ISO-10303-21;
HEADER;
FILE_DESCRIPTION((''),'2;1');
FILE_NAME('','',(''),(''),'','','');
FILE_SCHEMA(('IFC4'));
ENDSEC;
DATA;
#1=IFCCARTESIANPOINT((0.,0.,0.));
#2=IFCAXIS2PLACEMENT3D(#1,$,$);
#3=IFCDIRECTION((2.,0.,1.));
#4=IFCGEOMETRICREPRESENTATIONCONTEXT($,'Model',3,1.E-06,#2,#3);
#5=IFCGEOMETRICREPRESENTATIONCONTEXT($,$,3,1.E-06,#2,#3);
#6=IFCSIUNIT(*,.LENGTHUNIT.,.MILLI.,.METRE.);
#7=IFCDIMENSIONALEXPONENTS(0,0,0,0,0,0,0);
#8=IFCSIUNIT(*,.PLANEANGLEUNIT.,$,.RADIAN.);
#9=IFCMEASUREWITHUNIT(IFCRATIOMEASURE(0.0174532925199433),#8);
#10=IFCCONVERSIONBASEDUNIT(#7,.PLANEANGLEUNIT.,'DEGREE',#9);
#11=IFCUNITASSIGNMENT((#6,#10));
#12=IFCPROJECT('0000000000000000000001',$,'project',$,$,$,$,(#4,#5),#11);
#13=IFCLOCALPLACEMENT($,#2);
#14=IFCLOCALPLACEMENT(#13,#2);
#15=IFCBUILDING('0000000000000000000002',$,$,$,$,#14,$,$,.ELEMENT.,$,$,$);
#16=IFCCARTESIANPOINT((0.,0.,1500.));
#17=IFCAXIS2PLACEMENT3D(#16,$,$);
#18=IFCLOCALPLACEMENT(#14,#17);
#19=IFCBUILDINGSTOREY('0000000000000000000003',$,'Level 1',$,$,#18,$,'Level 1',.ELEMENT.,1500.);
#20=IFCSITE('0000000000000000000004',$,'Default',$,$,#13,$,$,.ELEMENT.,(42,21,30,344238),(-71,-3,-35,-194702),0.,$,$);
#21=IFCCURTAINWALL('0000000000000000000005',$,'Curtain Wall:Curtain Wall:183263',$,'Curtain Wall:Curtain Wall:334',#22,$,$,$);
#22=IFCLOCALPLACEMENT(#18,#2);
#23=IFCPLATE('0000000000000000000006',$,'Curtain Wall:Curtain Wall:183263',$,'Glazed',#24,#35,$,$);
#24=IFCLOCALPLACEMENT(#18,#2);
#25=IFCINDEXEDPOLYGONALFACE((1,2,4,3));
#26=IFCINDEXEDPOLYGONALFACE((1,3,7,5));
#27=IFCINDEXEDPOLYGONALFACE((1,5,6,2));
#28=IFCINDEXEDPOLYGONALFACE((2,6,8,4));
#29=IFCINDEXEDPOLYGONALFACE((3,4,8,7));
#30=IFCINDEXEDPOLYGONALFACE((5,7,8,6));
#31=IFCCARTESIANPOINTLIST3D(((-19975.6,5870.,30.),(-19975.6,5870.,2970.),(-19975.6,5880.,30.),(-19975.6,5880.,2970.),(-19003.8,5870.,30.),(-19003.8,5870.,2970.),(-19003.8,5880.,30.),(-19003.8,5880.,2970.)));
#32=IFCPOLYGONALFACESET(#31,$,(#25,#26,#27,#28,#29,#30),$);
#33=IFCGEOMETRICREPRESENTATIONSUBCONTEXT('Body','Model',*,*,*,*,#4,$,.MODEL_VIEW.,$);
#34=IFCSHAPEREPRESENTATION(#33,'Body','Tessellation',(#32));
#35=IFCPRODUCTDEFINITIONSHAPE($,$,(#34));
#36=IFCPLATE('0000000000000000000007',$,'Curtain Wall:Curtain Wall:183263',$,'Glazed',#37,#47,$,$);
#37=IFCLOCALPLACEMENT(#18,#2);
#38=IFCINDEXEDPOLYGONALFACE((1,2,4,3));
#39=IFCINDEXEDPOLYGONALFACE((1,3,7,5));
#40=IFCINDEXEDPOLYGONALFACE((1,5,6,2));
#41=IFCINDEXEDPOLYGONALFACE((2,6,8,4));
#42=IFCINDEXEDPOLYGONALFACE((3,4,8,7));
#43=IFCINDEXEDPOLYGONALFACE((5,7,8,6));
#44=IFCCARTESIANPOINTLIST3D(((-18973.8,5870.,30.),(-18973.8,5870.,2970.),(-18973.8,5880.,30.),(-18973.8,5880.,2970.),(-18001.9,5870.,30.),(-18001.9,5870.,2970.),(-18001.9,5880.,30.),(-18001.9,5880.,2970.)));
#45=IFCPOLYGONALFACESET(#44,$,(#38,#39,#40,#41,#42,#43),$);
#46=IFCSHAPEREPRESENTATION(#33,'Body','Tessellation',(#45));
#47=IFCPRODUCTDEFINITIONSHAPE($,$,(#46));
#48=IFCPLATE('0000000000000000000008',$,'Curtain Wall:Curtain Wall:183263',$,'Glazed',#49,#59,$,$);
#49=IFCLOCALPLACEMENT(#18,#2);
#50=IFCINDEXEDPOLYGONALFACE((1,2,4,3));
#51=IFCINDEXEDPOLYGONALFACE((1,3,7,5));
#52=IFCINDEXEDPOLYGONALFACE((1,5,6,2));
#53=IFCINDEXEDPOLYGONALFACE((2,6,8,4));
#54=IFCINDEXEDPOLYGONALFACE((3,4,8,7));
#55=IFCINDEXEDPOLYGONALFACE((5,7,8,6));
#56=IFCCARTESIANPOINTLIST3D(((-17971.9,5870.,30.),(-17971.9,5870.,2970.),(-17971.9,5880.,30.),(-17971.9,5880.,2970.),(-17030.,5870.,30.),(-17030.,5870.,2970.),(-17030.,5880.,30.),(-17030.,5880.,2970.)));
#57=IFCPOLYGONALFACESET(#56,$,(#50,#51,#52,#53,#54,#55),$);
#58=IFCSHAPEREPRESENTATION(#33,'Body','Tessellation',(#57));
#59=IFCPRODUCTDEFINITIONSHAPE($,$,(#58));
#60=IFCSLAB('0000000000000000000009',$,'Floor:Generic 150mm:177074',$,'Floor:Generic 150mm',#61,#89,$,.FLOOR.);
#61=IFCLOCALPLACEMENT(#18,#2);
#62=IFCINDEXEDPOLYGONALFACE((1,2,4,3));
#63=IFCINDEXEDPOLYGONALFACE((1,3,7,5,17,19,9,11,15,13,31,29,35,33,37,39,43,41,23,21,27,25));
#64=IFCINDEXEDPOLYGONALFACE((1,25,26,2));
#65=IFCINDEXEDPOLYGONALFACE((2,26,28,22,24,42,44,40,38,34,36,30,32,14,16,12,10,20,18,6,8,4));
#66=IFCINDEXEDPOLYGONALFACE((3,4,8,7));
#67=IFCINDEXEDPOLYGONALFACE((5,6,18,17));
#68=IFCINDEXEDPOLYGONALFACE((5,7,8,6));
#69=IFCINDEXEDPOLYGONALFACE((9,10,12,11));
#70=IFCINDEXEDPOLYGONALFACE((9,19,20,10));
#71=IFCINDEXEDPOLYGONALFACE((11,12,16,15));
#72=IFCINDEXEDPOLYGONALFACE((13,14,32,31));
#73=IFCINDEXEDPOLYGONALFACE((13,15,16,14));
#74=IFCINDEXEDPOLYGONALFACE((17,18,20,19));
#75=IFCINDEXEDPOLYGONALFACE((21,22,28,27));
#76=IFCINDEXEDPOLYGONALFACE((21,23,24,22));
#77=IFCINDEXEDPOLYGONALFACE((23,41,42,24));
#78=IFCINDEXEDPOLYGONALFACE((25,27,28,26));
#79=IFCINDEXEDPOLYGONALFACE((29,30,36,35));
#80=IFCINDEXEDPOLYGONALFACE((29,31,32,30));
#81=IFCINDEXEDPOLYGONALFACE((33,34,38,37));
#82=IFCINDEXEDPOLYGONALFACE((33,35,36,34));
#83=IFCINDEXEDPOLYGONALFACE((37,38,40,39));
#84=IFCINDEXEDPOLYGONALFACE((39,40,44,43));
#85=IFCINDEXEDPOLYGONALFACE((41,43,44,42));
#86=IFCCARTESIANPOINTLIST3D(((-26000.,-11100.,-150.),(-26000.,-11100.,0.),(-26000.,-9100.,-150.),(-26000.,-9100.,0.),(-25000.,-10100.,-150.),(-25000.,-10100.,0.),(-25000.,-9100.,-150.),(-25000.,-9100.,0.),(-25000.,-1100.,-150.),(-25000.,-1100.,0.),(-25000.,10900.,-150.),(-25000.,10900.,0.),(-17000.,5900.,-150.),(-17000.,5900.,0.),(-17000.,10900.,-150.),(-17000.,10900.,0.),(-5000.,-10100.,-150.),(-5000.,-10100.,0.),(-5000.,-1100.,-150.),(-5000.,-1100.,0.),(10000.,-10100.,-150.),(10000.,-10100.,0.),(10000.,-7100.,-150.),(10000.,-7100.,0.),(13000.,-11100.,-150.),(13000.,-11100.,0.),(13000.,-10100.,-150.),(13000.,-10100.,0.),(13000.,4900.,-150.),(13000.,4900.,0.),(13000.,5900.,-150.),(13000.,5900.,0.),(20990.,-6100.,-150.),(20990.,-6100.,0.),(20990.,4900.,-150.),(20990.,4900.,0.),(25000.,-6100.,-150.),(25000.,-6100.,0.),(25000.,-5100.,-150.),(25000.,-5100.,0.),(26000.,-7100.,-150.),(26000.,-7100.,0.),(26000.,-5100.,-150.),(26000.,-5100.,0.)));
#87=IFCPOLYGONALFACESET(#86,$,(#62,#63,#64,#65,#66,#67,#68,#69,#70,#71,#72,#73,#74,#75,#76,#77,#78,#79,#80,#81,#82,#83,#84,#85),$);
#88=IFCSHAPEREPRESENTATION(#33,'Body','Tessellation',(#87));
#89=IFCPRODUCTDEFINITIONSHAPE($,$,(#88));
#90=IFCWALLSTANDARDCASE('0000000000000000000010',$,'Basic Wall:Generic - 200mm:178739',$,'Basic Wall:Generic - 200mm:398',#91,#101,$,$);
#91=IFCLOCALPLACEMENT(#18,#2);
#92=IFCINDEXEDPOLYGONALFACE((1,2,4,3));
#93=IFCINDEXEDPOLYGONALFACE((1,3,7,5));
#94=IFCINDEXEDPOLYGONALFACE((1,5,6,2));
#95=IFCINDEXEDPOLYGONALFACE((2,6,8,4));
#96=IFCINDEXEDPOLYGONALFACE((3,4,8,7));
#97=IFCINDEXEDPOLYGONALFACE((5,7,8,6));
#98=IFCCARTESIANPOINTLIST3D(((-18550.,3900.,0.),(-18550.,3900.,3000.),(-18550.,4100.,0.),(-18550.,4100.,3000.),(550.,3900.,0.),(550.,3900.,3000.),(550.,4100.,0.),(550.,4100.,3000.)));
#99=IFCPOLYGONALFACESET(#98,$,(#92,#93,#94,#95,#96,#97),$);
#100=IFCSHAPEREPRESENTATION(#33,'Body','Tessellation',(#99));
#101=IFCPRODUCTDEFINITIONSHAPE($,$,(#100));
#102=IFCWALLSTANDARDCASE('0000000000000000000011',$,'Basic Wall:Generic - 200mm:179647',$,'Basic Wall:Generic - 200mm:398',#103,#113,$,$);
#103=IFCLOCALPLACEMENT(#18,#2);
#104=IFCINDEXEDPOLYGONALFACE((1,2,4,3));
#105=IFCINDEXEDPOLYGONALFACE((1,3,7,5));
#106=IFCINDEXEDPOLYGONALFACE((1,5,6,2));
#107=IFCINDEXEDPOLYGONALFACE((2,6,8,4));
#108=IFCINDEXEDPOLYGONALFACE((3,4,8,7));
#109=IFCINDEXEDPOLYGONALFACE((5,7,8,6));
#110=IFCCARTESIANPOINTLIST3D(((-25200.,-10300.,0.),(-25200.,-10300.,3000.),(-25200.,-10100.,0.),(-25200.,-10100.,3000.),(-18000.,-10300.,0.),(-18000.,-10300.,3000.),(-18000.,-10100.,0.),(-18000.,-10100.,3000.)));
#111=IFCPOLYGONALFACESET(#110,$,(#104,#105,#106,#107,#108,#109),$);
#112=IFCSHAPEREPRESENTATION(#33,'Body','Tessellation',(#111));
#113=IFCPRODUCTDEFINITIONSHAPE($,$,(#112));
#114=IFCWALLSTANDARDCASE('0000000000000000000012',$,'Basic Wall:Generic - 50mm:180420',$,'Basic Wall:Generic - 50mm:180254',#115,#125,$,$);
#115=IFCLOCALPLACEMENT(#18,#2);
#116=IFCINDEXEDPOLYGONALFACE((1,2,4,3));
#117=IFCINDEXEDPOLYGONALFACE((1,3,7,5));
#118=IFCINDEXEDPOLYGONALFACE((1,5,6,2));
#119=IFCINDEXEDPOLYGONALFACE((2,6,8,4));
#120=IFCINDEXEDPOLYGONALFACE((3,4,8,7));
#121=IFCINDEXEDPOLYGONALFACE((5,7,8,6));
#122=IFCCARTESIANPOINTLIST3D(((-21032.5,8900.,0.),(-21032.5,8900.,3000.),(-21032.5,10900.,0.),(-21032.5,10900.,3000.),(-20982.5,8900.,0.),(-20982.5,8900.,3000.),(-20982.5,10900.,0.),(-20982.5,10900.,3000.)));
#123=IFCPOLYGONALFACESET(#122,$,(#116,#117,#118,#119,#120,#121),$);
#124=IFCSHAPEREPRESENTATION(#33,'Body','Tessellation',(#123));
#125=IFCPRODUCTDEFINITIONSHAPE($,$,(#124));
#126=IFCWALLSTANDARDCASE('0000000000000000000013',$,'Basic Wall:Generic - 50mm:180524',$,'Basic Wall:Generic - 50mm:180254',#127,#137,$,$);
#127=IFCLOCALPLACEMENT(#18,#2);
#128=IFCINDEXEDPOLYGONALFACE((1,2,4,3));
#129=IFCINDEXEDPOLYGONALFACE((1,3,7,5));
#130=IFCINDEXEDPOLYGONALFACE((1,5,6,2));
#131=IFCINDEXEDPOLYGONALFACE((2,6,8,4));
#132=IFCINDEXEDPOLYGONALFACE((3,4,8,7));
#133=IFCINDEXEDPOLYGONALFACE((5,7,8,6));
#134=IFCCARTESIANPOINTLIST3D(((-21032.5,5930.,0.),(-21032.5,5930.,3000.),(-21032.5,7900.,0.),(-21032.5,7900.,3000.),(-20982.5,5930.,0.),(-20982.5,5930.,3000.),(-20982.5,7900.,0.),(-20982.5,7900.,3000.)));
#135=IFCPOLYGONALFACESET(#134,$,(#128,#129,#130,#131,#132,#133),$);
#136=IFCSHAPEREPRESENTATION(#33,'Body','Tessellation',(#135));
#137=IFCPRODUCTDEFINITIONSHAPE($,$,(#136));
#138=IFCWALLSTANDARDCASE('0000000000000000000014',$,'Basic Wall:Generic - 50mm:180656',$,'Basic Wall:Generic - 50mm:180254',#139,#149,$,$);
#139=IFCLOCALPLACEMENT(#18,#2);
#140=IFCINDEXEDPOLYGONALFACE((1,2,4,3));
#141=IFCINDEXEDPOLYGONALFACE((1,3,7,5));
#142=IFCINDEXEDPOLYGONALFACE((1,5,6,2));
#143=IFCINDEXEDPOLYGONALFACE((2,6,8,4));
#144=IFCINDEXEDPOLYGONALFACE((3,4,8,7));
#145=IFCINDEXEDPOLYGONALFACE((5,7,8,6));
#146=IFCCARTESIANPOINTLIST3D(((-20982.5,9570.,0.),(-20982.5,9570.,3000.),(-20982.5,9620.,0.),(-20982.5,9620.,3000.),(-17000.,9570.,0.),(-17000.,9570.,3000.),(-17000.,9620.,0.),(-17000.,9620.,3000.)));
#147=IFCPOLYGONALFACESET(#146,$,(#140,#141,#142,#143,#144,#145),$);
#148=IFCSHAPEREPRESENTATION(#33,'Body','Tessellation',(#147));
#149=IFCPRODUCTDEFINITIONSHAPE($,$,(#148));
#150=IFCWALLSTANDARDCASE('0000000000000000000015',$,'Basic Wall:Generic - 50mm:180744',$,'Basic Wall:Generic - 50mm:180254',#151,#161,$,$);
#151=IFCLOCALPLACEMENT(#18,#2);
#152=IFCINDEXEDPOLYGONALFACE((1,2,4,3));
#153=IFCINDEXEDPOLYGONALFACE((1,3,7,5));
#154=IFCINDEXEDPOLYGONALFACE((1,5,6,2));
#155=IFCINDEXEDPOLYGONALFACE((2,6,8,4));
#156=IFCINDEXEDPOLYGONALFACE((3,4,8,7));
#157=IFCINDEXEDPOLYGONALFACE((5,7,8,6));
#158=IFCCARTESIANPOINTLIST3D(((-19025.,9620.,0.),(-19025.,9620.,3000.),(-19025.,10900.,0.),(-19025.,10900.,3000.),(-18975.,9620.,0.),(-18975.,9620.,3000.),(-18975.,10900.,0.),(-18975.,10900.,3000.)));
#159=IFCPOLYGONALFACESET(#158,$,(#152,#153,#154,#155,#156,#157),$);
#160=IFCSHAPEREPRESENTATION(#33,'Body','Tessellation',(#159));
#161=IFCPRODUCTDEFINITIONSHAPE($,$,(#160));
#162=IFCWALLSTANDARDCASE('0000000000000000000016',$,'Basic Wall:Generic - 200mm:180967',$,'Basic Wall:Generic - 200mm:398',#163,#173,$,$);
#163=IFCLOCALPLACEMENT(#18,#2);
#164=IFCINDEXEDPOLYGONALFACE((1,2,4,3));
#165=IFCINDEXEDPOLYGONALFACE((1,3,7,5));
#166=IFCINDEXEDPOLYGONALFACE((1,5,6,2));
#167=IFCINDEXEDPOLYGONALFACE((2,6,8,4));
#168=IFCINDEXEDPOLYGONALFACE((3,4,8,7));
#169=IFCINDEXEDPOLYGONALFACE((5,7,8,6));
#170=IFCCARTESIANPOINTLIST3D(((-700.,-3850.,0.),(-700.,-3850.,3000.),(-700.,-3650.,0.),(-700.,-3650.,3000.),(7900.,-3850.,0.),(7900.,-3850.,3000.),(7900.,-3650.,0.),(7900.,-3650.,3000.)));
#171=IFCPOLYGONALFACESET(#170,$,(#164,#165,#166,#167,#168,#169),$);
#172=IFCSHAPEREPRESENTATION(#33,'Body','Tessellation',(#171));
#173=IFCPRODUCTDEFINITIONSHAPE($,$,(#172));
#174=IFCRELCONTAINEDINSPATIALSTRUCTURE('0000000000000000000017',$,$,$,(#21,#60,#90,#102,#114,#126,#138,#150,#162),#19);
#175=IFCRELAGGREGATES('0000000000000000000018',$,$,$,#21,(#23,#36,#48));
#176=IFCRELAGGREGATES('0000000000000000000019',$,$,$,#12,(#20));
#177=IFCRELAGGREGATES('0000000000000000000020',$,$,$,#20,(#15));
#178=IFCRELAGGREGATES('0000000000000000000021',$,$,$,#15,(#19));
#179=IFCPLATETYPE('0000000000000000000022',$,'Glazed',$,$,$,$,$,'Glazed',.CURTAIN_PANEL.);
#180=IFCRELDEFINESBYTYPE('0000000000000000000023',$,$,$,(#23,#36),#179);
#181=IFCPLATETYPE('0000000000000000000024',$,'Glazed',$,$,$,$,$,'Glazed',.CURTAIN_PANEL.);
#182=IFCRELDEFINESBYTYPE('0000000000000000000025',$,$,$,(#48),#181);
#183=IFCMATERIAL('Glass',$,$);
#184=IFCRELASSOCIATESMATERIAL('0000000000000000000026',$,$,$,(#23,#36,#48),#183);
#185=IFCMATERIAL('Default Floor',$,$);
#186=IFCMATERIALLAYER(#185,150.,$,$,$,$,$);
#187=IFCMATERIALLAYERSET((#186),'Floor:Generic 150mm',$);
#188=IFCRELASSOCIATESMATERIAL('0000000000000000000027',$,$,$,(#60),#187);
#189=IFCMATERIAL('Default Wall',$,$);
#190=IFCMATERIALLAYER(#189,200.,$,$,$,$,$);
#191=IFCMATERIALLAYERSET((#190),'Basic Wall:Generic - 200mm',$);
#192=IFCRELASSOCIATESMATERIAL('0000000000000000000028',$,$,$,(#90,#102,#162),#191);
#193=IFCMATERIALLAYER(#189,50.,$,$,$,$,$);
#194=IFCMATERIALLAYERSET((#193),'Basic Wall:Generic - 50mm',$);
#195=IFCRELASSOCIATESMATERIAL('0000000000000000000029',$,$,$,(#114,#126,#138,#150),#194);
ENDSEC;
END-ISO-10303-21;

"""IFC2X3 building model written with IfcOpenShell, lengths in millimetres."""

from ifc_helpers import new_model, entity, si_unit, converted_unit, direction, frame, frame_2d, origin, origin_2d_with_axis, place, context, subcontext, project, spatial, polyline, rectangle, outline, extrude, source, transform, mapped, material, layer, layer_set, layer_usage, type_object, type_shapes, element, aggregate, save


model = new_model("IFC2X3")

# Units and contexts
model_context = context("Model", 3, precision=1e-06, world=origin(), true_north=direction((2.0, 0.0, 1.0)))
context_of_model = context(None, 3, precision=1e-06, world=origin(), true_north=direction((2.0, 0.0, 1.0)))
body_context = subcontext(model_context, "Body", "Model", "MODEL_VIEW")
ifc_project = project(units=[si_unit("LENGTHUNIT", "METRE", prefix="MILLI"), converted_unit("PLANEANGLEUNIT", "DEGREE", entity("IfcRatioMeasure", 0.0174532925199433), si_unit("PLANEANGLEUNIT", "RADIAN"), dimensions=[0, 0, 0, 0, 0, 0, 0])], contexts=[model_context, context_of_model])

# Site, building, storey
site_placement = place(None, origin())
site = spatial("IfcSite", under=ifc_project, at=site_placement, Name="Default", CompositionType="ELEMENT", RefLatitude=(42, 21, 30, 344238), RefLongitude=(-71, -3, -35, -194702), RefElevation=0.0)
building_placement = place(site_placement, origin())
building = spatial("IfcBuilding", under=site, at=building_placement, CompositionType="ELEMENT")
storey_placement = place(building_placement, frame((0.0, 0.0, 1500.0)))
storey = spatial("IfcBuildingStorey", under=building, at=storey_placement, Name="Level 1", LongName="Level 1", CompositionType="ELEMENT", Elevation=1500.0)

# Curtain wall
curtain_wall_1_placement = place(storey_placement, origin())
curtain_wall_1 = element("IfcCurtainWall", 1, at=curtain_wall_1_placement, inside=storey, Name="Curtain Wall:Curtain Wall:183263", ObjectType="Curtain Wall:Curtain Wall:334")

# Plates
ifc_material_1 = material(Name="Glass")
plate_type_1 = type_object("IfcPlateType", Name="Glazed", ElementType="Glazed", PredefinedType="CURTAIN_PANEL")
shared_shape_1 = source(origin(), body_context, "Body", "SweptSolid", [
    extrude(rectangle(XDim=10.0, YDim=971.9, at=origin_2d_with_axis()), frame((0.0, 0.0, 0.0), z_axis=(0.0, 0.0, 1.0), x_axis=(0.0, 1.0, 0.0)), (0.0, 0.0, 1.0), 2940.0),
])
type_shapes(plate_type_1, [shared_shape_1])
plate_1_placement = place(storey_placement, frame((-19489.7, 5875.0, 30.0)))
plate_1 = element("IfcPlate", 2, at=plate_1_placement, type_object=plate_type_1, material=ifc_material_1, Name="Curtain Wall:Curtain Wall:183263", ObjectType="Glazed", context=body_context, shape_type="MappedRepresentation", body=[
    mapped(shared_shape_1, transform((0.0, 0.0, 0.0), scale=1.0)),
])
plate_2_placement = place(storey_placement, frame((-18487.8, 5875.0, 30.0)))
plate_2 = element("IfcPlate", 3, at=plate_2_placement, type_object=plate_type_1, material=ifc_material_1, Name="Curtain Wall:Curtain Wall:183263", ObjectType="Glazed", context=body_context, shape_type="MappedRepresentation", body=[
    mapped(shared_shape_1, transform((0.0, 0.0, 0.0), scale=1.0)),
])
plate_type_2 = type_object("IfcPlateType", Name="Glazed", ElementType="Glazed", PredefinedType="CURTAIN_PANEL")
shared_shape_2 = source(origin(), body_context, "Body", "SweptSolid", [
    extrude(rectangle(XDim=10.0, YDim=941.9, at=origin_2d_with_axis()), frame((0.0, 0.0, 0.0), z_axis=(0.0, 0.0, 1.0), x_axis=(0.0, 1.0, 0.0)), (0.0, 0.0, 1.0), 2940.0),
])
type_shapes(plate_type_2, [shared_shape_2])
plate_3_placement = place(storey_placement, frame((-17500.9, 5875.0, 30.0)))
plate_3 = element("IfcPlate", 4, at=plate_3_placement, type_object=plate_type_2, material=ifc_material_1, Name="Curtain Wall:Curtain Wall:183263", ObjectType="Glazed", context=body_context, shape_type="MappedRepresentation", body=[
    mapped(shared_shape_2, transform((0.0, 0.0, 0.0), scale=1.0)),
])
aggregate(curtain_wall_1, [plate_1, plate_2, plate_3])

# Slab
ifc_material_2 = material(Name="Default Floor")
ifc_layer_1 = layer(ifc_material_2, 150.0)
ifc_layer_set_1 = layer_set([ifc_layer_1], Name="Floor:Generic 150mm")
ifc_layer_usage_1 = layer_usage(ifc_layer_set_1, "AXIS3", "POSITIVE", 0.0)
slab_placement = place(storey_placement, frame((-26000.0, -11100.0, -150.0)))
element("IfcSlab", 5, at=slab_placement, inside=storey, material=ifc_layer_usage_1, Name="Floor:Generic 150mm:177074", ObjectType="Floor:Generic 150mm", PredefinedType="FLOOR", context=body_context, shape_type="SweptSolid", body=[
    extrude(outline(polyline([(26000.0, -9000.0), (25000.0, -9000.0), (25000.0, -10000.0), (5000.0, -10000.0), (5000.0, -1000.0), (25000.0, -1000.0), (25000.0, 11000.0), (17000.0, 11000.0), (17000.0, 6000.0), (-13000.0, 6000.0), (-13000.0, 5000.0), (-20990.0, 5000.0), (-20990.0, -6000.0), (-25000.0, -6000.0), (-25000.0, -5000.0), (-26000.0, -5000.0), (-26000.0, -7000.0), (-10000.0, -7000.0), (-10000.0, -10000.0), (-13000.0, -10000.0), (-13000.0, -11000.0), (26000.0, -11000.0), (26000.0, -9000.0)])), frame((26000.0, 11000.0, 150.0), z_axis=(0.0, 0.0, -1.0), x_axis=(-1.0, 0.0, 0.0)), (0.0, 0.0, 1.0), 150.0),
])

# Walls
ifc_material_3 = material(Name="Default Wall")
ifc_layer_2 = layer(ifc_material_3, 200.0)
ifc_layer_set_2 = layer_set([ifc_layer_2], Name="Basic Wall:Generic - 200mm")
ifc_layer_usage_2 = layer_usage(ifc_layer_set_2, "AXIS2", "NEGATIVE", 100.0)
wall_1_placement = place(storey_placement, frame((-18550.0, 4000.0, 0.0)))
element("IfcWallStandardCase", 6, at=wall_1_placement, inside=storey, material=ifc_layer_usage_2, Name="Basic Wall:Generic - 200mm:178739", ObjectType="Basic Wall:Generic - 200mm:398", context=body_context, shape_type="SweptSolid", body=[
    extrude(rectangle(XDim=19100.0, YDim=200.0, at=frame_2d((9550.0, 0.0), x_axis=(-1.0, 0.0))), origin(), (0.0, 0.0, 1.0), 3000.0),
])
ifc_layer_usage_3 = layer_usage(ifc_layer_set_2, "AXIS2", "NEGATIVE", 100.0)
wall_2_placement = place(storey_placement, frame((-18000.0, -10200.0, 0.0), z_axis=(0.0, 0.0, 1.0), x_axis=(-1.0, 0.0, 0.0)))
element("IfcWallStandardCase", 7, at=wall_2_placement, inside=storey, material=ifc_layer_usage_3, Name="Basic Wall:Generic - 200mm:179647", ObjectType="Basic Wall:Generic - 200mm:398", context=body_context, shape_type="SweptSolid", body=[
    extrude(rectangle(XDim=7200.0, YDim=200.0, at=frame_2d((3600.0, 0.0), x_axis=(-1.0, 0.0))), origin(), (0.0, 0.0, 1.0), 3000.0),
])
ifc_layer_3 = layer(ifc_material_3, 50.0)
ifc_layer_set_3 = layer_set([ifc_layer_3], Name="Basic Wall:Generic - 50mm")
ifc_layer_usage_4 = layer_usage(ifc_layer_set_3, "AXIS2", "NEGATIVE", 25.0)
wall_3_placement = place(storey_placement, frame((-21007.5, 10900.0, 0.0), z_axis=(0.0, 0.0, 1.0), x_axis=(0.0, -1.0, 0.0)))
element("IfcWallStandardCase", 8, at=wall_3_placement, inside=storey, material=ifc_layer_usage_4, Name="Basic Wall:Generic - 50mm:180420", ObjectType="Basic Wall:Generic - 50mm:180254", context=body_context, shape_type="SweptSolid", body=[
    extrude(rectangle(XDim=2000.0, YDim=50.0, at=frame_2d((1000.0, 0.0), x_axis=(-1.0, 0.0))), origin(), (0.0, 0.0, 1.0), 3000.0),
])
ifc_layer_usage_5 = layer_usage(ifc_layer_set_3, "AXIS2", "NEGATIVE", 25.0)
wall_4_placement = place(storey_placement, frame((-21007.5, 7900.0, 0.0), z_axis=(0.0, 0.0, 1.0), x_axis=(0.0, -1.0, 0.0)))
element("IfcWallStandardCase", 9, at=wall_4_placement, inside=storey, material=ifc_layer_usage_5, Name="Basic Wall:Generic - 50mm:180524", ObjectType="Basic Wall:Generic - 50mm:180254", context=body_context, shape_type="SweptSolid", body=[
    extrude(rectangle(XDim=1970.0, YDim=50.0, at=frame_2d((985.0, 0.0), x_axis=(-1.0, 0.0))), origin(), (0.0, 0.0, 1.0), 3000.0),
])
ifc_layer_usage_6 = layer_usage(ifc_layer_set_3, "AXIS2", "NEGATIVE", 25.0)
wall_5_placement = place(storey_placement, frame((-20982.5, 9595.0, 0.0)))
element("IfcWallStandardCase", 10, at=wall_5_placement, inside=storey, material=ifc_layer_usage_6, Name="Basic Wall:Generic - 50mm:180656", ObjectType="Basic Wall:Generic - 50mm:180254", context=body_context, shape_type="SweptSolid", body=[
    extrude(rectangle(XDim=3982.5, YDim=50.0, at=frame_2d((1991.2, 0.0), x_axis=(-1.0, 0.0))), origin(), (0.0, 0.0, 1.0), 3000.0),
])
ifc_layer_usage_7 = layer_usage(ifc_layer_set_3, "AXIS2", "NEGATIVE", 25.0)
wall_6_placement = place(storey_placement, frame((-19000.0, 9620.0, 0.0), z_axis=(0.0, 0.0, 1.0), x_axis=(0.0, 1.0, 0.0)))
element("IfcWallStandardCase", 11, at=wall_6_placement, inside=storey, material=ifc_layer_usage_7, Name="Basic Wall:Generic - 50mm:180744", ObjectType="Basic Wall:Generic - 50mm:180254", context=body_context, shape_type="SweptSolid", body=[
    extrude(rectangle(XDim=1280.0, YDim=50.0, at=frame_2d((640.0, 0.0), x_axis=(-1.0, 0.0))), origin(), (0.0, 0.0, 1.0), 3000.0),
])
ifc_layer_usage_8 = layer_usage(ifc_layer_set_2, "AXIS2", "NEGATIVE", 100.0)
wall_7_placement = place(storey_placement, frame((-700.0, -3750.0, 0.0)))
element("IfcWallStandardCase", 12, at=wall_7_placement, inside=storey, material=ifc_layer_usage_8, Name="Basic Wall:Generic - 200mm:180967", ObjectType="Basic Wall:Generic - 200mm:398", context=body_context, shape_type="SweptSolid", body=[
    extrude(rectangle(XDim=8600.0, YDim=200.0, at=frame_2d((4300.0, 0.0), x_axis=(-1.0, 0.0))), origin(), (0.0, 0.0, 1.0), 3000.0),
])

save(model, "model.ifc")
